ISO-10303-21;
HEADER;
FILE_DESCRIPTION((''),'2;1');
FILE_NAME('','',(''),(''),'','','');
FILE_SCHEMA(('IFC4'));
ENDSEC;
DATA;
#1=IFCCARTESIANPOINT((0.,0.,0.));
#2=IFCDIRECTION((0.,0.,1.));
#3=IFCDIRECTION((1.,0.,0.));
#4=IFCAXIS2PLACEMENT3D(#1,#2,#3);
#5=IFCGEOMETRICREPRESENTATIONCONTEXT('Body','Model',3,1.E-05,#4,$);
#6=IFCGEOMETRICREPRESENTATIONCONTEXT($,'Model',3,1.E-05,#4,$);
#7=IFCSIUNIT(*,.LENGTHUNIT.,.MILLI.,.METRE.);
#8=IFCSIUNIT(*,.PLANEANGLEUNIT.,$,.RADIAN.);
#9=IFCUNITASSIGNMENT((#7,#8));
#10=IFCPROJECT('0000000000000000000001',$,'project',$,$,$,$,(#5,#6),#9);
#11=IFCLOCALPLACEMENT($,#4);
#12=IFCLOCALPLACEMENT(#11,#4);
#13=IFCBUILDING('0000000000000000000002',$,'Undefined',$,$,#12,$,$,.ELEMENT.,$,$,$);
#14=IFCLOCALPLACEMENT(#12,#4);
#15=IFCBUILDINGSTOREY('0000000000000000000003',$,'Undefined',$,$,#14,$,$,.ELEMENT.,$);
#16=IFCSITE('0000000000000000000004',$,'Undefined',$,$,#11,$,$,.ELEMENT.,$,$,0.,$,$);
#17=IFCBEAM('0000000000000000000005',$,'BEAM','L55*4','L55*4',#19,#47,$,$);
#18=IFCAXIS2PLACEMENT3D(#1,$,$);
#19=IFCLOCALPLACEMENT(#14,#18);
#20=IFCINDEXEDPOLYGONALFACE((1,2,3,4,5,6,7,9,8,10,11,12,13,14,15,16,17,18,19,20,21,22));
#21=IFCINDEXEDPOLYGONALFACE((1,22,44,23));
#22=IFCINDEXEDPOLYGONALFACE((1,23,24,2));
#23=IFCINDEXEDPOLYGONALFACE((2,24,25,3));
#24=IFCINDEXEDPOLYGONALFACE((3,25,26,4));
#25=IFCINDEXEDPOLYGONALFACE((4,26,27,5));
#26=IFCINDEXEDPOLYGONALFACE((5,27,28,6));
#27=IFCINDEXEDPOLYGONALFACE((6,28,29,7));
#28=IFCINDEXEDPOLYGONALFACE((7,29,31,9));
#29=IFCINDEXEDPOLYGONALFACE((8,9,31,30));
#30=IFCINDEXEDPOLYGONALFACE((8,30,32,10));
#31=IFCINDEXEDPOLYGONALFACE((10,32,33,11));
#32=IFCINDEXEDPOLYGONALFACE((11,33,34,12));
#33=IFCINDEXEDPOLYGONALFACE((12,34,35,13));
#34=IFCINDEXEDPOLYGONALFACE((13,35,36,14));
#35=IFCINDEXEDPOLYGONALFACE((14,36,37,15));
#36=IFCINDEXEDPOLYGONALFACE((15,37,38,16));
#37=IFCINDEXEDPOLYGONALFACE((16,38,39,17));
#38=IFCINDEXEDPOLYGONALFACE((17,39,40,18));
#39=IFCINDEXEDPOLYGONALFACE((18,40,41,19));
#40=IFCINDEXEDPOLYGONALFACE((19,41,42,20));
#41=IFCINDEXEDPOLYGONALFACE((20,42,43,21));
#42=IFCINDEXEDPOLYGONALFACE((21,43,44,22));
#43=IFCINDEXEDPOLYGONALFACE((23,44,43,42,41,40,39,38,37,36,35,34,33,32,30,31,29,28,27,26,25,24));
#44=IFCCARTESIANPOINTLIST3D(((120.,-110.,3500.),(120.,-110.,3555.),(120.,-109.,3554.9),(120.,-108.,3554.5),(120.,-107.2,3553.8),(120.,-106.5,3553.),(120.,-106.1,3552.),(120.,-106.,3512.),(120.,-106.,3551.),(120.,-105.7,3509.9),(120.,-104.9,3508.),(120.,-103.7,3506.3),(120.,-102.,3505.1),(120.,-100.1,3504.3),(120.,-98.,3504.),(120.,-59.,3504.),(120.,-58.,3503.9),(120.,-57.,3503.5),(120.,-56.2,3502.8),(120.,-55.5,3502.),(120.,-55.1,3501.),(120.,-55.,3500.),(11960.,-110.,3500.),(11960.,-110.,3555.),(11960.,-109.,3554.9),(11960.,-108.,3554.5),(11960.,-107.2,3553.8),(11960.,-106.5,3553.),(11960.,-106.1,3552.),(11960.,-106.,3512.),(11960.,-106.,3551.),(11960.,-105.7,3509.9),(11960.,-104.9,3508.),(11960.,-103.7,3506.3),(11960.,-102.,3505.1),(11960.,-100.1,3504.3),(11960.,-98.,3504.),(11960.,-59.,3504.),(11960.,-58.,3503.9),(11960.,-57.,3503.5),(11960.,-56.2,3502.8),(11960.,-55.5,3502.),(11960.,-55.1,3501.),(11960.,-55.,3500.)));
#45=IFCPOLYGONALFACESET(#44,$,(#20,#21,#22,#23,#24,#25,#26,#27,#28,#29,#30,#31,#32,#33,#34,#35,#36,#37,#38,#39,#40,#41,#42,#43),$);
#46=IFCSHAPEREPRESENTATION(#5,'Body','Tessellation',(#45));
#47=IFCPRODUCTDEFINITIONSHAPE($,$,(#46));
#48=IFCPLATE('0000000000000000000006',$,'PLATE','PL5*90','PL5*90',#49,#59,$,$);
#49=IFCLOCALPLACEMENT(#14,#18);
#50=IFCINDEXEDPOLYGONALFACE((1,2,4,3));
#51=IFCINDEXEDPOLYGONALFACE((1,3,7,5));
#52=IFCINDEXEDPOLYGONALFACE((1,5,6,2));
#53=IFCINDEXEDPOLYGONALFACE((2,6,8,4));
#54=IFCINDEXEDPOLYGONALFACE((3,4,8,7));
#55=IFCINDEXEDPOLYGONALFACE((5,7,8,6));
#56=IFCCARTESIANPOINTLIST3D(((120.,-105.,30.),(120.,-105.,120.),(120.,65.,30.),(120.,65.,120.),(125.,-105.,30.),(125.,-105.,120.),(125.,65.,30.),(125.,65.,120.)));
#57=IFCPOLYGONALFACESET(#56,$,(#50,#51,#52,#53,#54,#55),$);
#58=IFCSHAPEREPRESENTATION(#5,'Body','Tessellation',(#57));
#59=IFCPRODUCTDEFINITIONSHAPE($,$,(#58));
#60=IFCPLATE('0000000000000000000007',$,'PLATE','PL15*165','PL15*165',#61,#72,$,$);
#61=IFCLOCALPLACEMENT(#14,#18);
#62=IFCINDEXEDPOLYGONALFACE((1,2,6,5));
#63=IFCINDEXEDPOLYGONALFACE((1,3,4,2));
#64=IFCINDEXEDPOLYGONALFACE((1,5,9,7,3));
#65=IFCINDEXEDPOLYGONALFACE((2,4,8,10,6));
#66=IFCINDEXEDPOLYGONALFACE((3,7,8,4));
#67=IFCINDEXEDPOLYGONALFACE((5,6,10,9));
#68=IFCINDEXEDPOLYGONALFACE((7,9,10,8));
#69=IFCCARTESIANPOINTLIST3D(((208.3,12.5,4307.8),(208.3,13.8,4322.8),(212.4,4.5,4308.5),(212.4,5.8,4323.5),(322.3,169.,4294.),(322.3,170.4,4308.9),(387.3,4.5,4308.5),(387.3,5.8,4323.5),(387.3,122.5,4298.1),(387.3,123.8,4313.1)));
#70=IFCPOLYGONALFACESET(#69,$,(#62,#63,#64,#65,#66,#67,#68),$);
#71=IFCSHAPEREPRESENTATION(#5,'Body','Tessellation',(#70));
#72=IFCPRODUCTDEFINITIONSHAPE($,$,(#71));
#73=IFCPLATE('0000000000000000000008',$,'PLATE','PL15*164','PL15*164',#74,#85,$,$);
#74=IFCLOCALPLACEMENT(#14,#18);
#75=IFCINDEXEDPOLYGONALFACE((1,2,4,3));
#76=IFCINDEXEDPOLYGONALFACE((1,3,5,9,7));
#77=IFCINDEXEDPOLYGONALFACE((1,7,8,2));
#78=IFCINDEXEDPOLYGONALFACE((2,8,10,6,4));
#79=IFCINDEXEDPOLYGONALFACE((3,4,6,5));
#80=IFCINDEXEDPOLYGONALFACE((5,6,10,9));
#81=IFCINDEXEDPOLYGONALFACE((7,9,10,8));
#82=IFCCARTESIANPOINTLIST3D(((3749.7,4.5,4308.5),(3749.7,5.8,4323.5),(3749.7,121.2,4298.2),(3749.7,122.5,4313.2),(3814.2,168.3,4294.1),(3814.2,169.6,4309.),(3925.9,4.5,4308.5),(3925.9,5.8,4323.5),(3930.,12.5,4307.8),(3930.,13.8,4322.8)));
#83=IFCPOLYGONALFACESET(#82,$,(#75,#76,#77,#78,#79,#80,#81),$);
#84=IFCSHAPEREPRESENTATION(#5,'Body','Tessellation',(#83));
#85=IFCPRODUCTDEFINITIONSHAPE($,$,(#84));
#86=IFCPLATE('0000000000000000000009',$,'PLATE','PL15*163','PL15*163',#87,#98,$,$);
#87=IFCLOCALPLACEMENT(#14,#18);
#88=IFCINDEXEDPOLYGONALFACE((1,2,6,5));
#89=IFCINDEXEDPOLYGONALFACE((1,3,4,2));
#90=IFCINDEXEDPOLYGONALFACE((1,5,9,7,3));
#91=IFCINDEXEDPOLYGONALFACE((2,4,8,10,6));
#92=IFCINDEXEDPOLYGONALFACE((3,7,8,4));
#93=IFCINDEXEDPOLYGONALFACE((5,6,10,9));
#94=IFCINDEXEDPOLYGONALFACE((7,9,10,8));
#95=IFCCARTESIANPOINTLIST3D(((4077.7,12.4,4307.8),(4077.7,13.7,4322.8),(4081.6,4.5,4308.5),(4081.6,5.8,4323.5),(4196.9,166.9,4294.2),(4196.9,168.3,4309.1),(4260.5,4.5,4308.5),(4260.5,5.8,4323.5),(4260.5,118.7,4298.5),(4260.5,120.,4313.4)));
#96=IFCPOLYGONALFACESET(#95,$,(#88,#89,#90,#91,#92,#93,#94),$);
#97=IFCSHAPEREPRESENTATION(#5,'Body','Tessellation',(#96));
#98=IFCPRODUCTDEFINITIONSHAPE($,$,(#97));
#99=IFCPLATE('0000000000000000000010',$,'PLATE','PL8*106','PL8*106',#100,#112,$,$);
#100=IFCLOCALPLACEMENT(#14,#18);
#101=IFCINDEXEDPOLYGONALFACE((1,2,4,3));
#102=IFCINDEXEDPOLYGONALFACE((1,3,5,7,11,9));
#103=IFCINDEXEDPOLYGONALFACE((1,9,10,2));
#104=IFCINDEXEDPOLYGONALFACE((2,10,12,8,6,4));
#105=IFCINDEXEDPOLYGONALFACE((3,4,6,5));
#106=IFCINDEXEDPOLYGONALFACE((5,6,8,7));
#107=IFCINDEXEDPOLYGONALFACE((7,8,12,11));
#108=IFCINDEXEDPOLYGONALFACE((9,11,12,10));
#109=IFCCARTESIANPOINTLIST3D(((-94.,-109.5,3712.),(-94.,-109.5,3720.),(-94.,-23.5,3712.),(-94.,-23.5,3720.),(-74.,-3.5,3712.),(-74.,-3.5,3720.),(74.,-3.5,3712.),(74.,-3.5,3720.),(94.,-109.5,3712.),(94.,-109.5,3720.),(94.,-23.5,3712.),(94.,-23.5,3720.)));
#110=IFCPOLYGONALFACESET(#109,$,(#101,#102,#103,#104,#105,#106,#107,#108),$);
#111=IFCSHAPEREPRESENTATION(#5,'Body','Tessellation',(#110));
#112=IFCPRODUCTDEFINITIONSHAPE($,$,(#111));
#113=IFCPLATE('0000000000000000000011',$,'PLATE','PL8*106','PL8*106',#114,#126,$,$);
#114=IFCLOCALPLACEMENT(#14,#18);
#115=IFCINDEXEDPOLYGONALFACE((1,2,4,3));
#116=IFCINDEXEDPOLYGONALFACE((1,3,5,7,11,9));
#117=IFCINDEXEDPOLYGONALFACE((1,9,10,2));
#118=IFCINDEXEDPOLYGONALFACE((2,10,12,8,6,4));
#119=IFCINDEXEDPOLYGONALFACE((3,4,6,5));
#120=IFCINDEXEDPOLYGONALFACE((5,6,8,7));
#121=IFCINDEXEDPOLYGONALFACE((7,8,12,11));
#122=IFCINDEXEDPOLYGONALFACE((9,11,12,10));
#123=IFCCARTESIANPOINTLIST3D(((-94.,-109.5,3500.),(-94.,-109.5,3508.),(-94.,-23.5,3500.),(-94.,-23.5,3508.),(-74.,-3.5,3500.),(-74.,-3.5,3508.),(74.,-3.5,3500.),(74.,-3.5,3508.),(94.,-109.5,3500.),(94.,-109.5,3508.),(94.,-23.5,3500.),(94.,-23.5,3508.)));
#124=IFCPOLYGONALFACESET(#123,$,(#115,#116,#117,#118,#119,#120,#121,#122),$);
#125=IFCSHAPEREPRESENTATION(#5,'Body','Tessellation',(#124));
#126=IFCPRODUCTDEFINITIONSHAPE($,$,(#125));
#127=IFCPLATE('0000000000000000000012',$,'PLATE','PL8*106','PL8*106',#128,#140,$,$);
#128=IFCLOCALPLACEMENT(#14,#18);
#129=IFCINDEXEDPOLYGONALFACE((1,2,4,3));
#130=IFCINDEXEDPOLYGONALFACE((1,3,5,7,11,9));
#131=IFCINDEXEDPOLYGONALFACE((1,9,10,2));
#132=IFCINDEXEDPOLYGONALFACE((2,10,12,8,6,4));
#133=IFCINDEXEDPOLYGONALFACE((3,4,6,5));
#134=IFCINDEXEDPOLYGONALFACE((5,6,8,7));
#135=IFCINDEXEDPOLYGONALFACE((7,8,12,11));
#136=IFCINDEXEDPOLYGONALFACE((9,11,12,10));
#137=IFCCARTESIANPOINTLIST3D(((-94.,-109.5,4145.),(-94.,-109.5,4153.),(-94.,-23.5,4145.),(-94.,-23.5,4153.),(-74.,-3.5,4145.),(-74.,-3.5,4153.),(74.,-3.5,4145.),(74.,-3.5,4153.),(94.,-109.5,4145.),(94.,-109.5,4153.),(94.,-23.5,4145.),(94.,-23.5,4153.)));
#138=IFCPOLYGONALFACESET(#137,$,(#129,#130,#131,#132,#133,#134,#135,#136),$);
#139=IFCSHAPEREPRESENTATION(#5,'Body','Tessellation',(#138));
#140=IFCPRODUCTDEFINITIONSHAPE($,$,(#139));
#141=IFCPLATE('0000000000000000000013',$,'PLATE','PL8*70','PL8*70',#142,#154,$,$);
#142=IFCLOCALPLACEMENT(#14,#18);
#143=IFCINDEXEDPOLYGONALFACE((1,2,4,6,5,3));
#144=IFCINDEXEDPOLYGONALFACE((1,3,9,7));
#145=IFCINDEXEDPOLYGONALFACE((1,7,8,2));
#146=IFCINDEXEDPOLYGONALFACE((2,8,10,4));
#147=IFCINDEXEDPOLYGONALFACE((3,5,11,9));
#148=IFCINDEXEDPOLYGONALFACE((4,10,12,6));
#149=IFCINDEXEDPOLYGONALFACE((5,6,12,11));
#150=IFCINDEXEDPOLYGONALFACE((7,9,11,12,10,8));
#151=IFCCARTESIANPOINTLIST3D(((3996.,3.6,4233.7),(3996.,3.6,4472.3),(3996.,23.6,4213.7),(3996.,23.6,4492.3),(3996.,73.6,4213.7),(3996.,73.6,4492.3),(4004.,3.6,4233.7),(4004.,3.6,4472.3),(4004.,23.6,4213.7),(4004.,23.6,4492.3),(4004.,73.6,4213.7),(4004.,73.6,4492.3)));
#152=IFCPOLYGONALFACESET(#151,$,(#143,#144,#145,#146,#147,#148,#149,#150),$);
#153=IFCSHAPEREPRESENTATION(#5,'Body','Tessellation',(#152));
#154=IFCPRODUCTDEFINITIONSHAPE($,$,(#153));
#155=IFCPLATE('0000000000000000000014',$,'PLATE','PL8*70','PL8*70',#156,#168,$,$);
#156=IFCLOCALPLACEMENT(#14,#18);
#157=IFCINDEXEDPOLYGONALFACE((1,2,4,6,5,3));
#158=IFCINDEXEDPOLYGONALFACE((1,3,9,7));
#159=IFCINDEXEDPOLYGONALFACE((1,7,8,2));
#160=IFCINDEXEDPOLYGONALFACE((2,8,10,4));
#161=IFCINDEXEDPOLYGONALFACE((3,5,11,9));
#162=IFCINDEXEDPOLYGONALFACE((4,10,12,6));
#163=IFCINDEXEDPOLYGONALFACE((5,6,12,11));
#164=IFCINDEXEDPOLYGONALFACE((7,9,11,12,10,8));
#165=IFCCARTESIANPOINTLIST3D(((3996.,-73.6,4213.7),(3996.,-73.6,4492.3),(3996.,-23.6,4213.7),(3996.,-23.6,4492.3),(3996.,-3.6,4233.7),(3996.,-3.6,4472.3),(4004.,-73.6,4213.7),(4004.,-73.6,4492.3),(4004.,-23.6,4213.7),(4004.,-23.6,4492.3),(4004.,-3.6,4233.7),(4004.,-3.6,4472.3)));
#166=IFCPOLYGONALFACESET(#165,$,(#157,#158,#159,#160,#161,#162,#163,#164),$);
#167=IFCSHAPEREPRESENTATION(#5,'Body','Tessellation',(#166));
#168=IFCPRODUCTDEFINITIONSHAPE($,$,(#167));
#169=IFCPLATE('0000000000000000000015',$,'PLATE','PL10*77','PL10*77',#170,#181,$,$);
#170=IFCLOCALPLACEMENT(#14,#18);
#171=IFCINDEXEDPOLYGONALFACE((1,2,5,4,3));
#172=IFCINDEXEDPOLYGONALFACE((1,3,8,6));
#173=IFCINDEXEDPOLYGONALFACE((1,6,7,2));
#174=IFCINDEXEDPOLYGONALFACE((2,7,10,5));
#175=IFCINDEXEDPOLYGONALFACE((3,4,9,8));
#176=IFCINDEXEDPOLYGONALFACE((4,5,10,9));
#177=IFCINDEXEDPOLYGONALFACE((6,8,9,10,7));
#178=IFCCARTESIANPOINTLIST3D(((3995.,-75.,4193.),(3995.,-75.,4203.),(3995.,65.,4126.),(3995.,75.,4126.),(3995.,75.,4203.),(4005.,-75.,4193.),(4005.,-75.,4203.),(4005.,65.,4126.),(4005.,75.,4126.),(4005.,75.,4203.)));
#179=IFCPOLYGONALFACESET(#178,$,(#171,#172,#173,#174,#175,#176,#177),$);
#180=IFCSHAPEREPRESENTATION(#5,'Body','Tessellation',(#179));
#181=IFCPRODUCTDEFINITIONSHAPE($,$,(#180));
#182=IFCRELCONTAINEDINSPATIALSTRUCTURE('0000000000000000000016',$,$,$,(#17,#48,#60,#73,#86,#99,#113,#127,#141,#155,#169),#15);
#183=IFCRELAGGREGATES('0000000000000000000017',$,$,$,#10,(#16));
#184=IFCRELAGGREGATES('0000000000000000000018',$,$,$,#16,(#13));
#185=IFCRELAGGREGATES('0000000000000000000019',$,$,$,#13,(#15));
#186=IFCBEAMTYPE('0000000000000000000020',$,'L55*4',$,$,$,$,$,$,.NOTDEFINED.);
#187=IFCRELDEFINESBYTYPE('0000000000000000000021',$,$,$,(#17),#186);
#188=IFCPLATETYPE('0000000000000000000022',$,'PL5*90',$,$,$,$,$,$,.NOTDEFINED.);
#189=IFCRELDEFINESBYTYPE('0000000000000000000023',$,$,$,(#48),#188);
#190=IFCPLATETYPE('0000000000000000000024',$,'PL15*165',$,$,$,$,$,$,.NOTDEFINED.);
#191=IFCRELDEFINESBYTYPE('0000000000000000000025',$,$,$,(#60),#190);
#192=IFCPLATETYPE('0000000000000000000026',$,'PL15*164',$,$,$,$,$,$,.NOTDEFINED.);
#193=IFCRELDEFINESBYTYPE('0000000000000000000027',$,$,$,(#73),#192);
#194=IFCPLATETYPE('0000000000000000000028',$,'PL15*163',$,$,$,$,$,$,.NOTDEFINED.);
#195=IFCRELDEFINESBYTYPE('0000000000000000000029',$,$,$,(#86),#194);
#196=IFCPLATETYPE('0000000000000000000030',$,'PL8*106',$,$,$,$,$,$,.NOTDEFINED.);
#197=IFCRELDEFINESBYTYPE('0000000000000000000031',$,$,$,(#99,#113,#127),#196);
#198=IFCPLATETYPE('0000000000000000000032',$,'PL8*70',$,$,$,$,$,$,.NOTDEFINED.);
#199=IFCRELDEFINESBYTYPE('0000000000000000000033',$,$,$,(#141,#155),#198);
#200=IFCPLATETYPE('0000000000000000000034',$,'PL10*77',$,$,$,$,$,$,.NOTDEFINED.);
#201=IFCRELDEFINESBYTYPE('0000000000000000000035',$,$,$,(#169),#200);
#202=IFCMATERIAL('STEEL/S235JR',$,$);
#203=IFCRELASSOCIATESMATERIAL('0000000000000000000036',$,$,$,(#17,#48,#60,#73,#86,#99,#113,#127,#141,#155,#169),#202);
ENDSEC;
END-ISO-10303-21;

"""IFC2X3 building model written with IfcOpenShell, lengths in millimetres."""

from ifc_helpers import new_model, si_unit, frame, origin_with_axes, origin_2d_with_axis, place, context, project, spatial, polyline, l_section, outline, extrude, material, type_object, element, save


model = new_model("IFC2X3")

# Units and contexts
model_context_1 = context("Model", 3, precision=1e-05, world=origin_with_axes(), identifier="Body")
model_context_2 = context("Model", 3, precision=1e-05, world=origin_with_axes())
ifc_project = project(units=[si_unit("LENGTHUNIT", "METRE", prefix="MILLI"), si_unit("PLANEANGLEUNIT", "RADIAN")], contexts=[model_context_1, model_context_2])

# Site, building, storey
site_placement = place(None, origin_with_axes())
site = spatial("IfcSite", under=ifc_project, at=site_placement, Name="Undefined", CompositionType="ELEMENT", RefElevation=0.0)
building_placement = place(site_placement, origin_with_axes())
building = spatial("IfcBuilding", under=site, at=building_placement, Name="Undefined", CompositionType="ELEMENT")
storey_placement = place(building_placement, origin_with_axes())
storey = spatial("IfcBuildingStorey", under=building, at=storey_placement, Name="Undefined", CompositionType="ELEMENT")

# Shared definitions
ifc_material = material(Name="STEEL/S235JR")

# Beam
beam_type_1 = type_object("IfcBeamType", Name="L55*4", PredefinedType="NOTDEFINED")
beam_1_placement = place(storey_placement, frame((120.0, -82.5, 3527.5), z_axis=(0.0, 1.0, 0.0), x_axis=(1.0, 0.0, 0.0)))
element("IfcBeam", 1, at=beam_1_placement, inside=storey, type_object=beam_type_1, material=ifc_material, Name="BEAM", Description="L55*4", ObjectType="L55*4", context=model_context_1, shape_type="SweptSolid", body=[
    extrude(l_section(Depth=55.0, Width=55.0, Thickness=4.0, FilletRadius=8.0, EdgeRadius=4.0, at=origin_2d_with_axis()), frame((11840.0, 0.0, 0.0), z_axis=(-1.0, 0.0, 0.0), x_axis=(0.0, -1.0, 0.0)), (0.0, 0.0, 1.0), 11840.0),
])

# Plates
plate_type_1 = type_object("IfcPlateType", Name="PL5*90", PredefinedType="NOTDEFINED")
plate_1_placement = place(storey_placement, frame((122.5, 65.0, 120.0), z_axis=(1.0, 0.0, 0.0), x_axis=(0.0, -1.0, 0.0)))
element("IfcPlate", 2, at=plate_1_placement, inside=storey, type_object=plate_type_1, material=ifc_material, Name="PLATE", Description="PL5*90", ObjectType="PL5*90", context=model_context_1, shape_type="SweptSolid", body=[
    extrude(outline(polyline([(0.0, 0.0), (170.0, 0.0), (170.0, 90.0), (0.0, 90.0), (0.0, 0.0)])), frame((0.0, 0.0, -2.5), z_axis=(0.0, 0.0, 1.0), x_axis=(1.0, 0.0, 0.0)), (0.0, 0.0, 1.0), 5.0),
])
plate_type_2 = type_object("IfcPlateType", Name="PL15*165", PredefinedType="NOTDEFINED")
plate_2_placement = place(storey_placement, frame((387.3, 5.1, 4316.0), z_axis=(0.000003, -0.088001, -0.99612), x_axis=(-1.0, 0.0, 0.0)))
element("IfcPlate", 3, at=plate_2_placement, inside=storey, type_object=plate_type_2, material=ifc_material, Name="PLATE", Description="PL15*165", ObjectType="PL15*165", context=model_context_1, shape_type="SweptSolid", body=[
    extrude(outline(polyline([(0.0, 0.0), (174.8, 0.0), (179.0, 8.1), (65.0, 165.2), (0.0, 118.5), (0.0, 0.0)])), frame((0.0, 0.0, -7.5), z_axis=(0.0, 0.0, 1.0), x_axis=(1.0, 0.0, 0.0)), (0.0, 0.0, 1.0), 15.0),
])
plate_type_3 = type_object("IfcPlateType", Name="PL15*164", PredefinedType="NOTDEFINED")
plate_3_placement = place(storey_placement, frame((3935.9, 5.1, 4316.0), z_axis=(0.000003, -0.088001, -0.99612), x_axis=(-1.0, 0.0, 0.0)))
element("IfcPlate", 4, at=plate_3_placement, inside=storey, type_object=plate_type_3, material=ifc_material, Name="PLATE", Description="PL15*164", ObjectType="PL15*164", context=model_context_1, shape_type="SweptSolid", body=[
    extrude(outline(polyline([(5.9, 8.0), (10.0, 0.0), (186.3, 0.0), (186.3, 117.2), (121.7, 164.5), (5.9, 8.0)])), frame((0.0, 0.0, -7.5), z_axis=(0.0, 0.0, 1.0), x_axis=(1.0, 0.0, 0.0)), (0.0, 0.0, 1.0), 15.0),
])
plate_type_4 = type_object("IfcPlateType", Name="PL15*163", PredefinedType="NOTDEFINED")
plate_4_placement = place(storey_placement, frame((4260.5, 5.1, 4316.0), z_axis=(0.000003, -0.088001, -0.99612), x_axis=(-1.0, 0.0, 0.0)))
element("IfcPlate", 5, at=plate_4_placement, inside=storey, type_object=plate_type_4, material=ifc_material, Name="PLATE", Description="PL15*163", ObjectType="PL15*163", context=model_context_1, shape_type="SweptSolid", body=[
    extrude(outline(polyline([(0.0, 0.0), (178.9, 0.0), (182.8, 7.9), (63.7, 163.1), (0.0, 114.7), (0.0, 0.0)])), frame((0.0, 0.0, -7.5), z_axis=(0.0, 0.0, 1.0), x_axis=(1.0, 0.0, 0.0)), (0.0, 0.0, 1.0), 15.0),
])
plate_type_5 = type_object("IfcPlateType", Name="PL8*106", PredefinedType="NOTDEFINED")
for number, where, z_axis, x_axis, name in (
    (6, (94.0, -109.5, 3716.0), (0.0, 0.0, 1.0), (0.0, 1.0, 0.0), "PLATE"),
    (7, (94.0, -109.5, 3504.0), (0.0, 0.0, 1.0), (0.0, 1.0, 0.0), "PLATE"),
    (8, (94.0, -109.5, 4149.0), (0.0, 0.0, 1.0), (0.0, 1.0, 0.0), "PLATE"),
):
    element("IfcPlate", number, at=place(storey_placement, frame(where, z_axis=z_axis, x_axis=x_axis)), inside=storey, type_object=plate_type_5, material=ifc_material, Name=name, Description="PL8*106", ObjectType="PL8*106", context=model_context_1, shape_type="SweptSolid", body=[
        extrude(outline(polyline([(0.0, 0.0), (86.0, 0.0), (106.0, 20.0), (106.0, 168.0), (86.0, 188.0), (0.0, 188.0), (0.0, 0.0)])), frame((0.0, 0.0, -4.0), z_axis=(0.0, 0.0, 1.0), x_axis=(1.0, 0.0, 0.0)), (0.0, 0.0, 1.0), 8.0),
    ])
plate_type_6 = type_object("IfcPlateType", Name="PL8*70", PredefinedType="NOTDEFINED")
for number, where, z_axis, x_axis, name in (
    (9, (4000.0, 3.6, 4213.7), (1.0, 0.0, 0.0), (0.0, 1.0, 0.0), "PLATE"),
    (10, (4000.0, -3.6, 4213.7), (-1.0, 0.0, 0.0), (0.0, -1.0, 0.0), "PLATE"),
):
    element("IfcPlate", number, at=place(storey_placement, frame(where, z_axis=z_axis, x_axis=x_axis)), inside=storey, type_object=plate_type_6, material=ifc_material, Name=name, Description="PL8*70", ObjectType="PL8*70", context=model_context_1, shape_type="SweptSolid", body=[
        extrude(outline(polyline([(0.0, 20.0), (20.0, 0.0), (70.0, 0.0), (70.0, 278.6), (20.0, 278.6), (0.0, 258.6), (0.0, 20.0)])), frame((0.0, 0.0, -4.0), z_axis=(0.0, 0.0, 1.0), x_axis=(1.0, 0.0, 0.0)), (0.0, 0.0, 1.0), 8.0),
    ])
plate_type_7 = type_object("IfcPlateType", Name="PL10*77", PredefinedType="NOTDEFINED")
plate_5_placement = place(storey_placement, frame((4000.0, 75.0, 4126.0), z_axis=(1.0, 0.0, 0.0), x_axis=(0.0, 0.0, 1.0)))
element("IfcPlate", 11, at=plate_5_placement, inside=storey, type_object=plate_type_7, material=ifc_material, Name="PLATE", Description="PL10*77", ObjectType="PL10*77", context=model_context_1, shape_type="SweptSolid", body=[
    extrude(outline(polyline([(0.0, 0.0), (77.0, 0.0), (77.0, 150.0), (67.0, 150.0), (0.0, 10.0), (0.0, 0.0)])), frame((0.0, 0.0, -5.0), z_axis=(0.0, 0.0, 1.0), x_axis=(1.0, 0.0, 0.0)), (0.0, 0.0, 1.0), 10.0),
])

save(model, "model.ifc")
